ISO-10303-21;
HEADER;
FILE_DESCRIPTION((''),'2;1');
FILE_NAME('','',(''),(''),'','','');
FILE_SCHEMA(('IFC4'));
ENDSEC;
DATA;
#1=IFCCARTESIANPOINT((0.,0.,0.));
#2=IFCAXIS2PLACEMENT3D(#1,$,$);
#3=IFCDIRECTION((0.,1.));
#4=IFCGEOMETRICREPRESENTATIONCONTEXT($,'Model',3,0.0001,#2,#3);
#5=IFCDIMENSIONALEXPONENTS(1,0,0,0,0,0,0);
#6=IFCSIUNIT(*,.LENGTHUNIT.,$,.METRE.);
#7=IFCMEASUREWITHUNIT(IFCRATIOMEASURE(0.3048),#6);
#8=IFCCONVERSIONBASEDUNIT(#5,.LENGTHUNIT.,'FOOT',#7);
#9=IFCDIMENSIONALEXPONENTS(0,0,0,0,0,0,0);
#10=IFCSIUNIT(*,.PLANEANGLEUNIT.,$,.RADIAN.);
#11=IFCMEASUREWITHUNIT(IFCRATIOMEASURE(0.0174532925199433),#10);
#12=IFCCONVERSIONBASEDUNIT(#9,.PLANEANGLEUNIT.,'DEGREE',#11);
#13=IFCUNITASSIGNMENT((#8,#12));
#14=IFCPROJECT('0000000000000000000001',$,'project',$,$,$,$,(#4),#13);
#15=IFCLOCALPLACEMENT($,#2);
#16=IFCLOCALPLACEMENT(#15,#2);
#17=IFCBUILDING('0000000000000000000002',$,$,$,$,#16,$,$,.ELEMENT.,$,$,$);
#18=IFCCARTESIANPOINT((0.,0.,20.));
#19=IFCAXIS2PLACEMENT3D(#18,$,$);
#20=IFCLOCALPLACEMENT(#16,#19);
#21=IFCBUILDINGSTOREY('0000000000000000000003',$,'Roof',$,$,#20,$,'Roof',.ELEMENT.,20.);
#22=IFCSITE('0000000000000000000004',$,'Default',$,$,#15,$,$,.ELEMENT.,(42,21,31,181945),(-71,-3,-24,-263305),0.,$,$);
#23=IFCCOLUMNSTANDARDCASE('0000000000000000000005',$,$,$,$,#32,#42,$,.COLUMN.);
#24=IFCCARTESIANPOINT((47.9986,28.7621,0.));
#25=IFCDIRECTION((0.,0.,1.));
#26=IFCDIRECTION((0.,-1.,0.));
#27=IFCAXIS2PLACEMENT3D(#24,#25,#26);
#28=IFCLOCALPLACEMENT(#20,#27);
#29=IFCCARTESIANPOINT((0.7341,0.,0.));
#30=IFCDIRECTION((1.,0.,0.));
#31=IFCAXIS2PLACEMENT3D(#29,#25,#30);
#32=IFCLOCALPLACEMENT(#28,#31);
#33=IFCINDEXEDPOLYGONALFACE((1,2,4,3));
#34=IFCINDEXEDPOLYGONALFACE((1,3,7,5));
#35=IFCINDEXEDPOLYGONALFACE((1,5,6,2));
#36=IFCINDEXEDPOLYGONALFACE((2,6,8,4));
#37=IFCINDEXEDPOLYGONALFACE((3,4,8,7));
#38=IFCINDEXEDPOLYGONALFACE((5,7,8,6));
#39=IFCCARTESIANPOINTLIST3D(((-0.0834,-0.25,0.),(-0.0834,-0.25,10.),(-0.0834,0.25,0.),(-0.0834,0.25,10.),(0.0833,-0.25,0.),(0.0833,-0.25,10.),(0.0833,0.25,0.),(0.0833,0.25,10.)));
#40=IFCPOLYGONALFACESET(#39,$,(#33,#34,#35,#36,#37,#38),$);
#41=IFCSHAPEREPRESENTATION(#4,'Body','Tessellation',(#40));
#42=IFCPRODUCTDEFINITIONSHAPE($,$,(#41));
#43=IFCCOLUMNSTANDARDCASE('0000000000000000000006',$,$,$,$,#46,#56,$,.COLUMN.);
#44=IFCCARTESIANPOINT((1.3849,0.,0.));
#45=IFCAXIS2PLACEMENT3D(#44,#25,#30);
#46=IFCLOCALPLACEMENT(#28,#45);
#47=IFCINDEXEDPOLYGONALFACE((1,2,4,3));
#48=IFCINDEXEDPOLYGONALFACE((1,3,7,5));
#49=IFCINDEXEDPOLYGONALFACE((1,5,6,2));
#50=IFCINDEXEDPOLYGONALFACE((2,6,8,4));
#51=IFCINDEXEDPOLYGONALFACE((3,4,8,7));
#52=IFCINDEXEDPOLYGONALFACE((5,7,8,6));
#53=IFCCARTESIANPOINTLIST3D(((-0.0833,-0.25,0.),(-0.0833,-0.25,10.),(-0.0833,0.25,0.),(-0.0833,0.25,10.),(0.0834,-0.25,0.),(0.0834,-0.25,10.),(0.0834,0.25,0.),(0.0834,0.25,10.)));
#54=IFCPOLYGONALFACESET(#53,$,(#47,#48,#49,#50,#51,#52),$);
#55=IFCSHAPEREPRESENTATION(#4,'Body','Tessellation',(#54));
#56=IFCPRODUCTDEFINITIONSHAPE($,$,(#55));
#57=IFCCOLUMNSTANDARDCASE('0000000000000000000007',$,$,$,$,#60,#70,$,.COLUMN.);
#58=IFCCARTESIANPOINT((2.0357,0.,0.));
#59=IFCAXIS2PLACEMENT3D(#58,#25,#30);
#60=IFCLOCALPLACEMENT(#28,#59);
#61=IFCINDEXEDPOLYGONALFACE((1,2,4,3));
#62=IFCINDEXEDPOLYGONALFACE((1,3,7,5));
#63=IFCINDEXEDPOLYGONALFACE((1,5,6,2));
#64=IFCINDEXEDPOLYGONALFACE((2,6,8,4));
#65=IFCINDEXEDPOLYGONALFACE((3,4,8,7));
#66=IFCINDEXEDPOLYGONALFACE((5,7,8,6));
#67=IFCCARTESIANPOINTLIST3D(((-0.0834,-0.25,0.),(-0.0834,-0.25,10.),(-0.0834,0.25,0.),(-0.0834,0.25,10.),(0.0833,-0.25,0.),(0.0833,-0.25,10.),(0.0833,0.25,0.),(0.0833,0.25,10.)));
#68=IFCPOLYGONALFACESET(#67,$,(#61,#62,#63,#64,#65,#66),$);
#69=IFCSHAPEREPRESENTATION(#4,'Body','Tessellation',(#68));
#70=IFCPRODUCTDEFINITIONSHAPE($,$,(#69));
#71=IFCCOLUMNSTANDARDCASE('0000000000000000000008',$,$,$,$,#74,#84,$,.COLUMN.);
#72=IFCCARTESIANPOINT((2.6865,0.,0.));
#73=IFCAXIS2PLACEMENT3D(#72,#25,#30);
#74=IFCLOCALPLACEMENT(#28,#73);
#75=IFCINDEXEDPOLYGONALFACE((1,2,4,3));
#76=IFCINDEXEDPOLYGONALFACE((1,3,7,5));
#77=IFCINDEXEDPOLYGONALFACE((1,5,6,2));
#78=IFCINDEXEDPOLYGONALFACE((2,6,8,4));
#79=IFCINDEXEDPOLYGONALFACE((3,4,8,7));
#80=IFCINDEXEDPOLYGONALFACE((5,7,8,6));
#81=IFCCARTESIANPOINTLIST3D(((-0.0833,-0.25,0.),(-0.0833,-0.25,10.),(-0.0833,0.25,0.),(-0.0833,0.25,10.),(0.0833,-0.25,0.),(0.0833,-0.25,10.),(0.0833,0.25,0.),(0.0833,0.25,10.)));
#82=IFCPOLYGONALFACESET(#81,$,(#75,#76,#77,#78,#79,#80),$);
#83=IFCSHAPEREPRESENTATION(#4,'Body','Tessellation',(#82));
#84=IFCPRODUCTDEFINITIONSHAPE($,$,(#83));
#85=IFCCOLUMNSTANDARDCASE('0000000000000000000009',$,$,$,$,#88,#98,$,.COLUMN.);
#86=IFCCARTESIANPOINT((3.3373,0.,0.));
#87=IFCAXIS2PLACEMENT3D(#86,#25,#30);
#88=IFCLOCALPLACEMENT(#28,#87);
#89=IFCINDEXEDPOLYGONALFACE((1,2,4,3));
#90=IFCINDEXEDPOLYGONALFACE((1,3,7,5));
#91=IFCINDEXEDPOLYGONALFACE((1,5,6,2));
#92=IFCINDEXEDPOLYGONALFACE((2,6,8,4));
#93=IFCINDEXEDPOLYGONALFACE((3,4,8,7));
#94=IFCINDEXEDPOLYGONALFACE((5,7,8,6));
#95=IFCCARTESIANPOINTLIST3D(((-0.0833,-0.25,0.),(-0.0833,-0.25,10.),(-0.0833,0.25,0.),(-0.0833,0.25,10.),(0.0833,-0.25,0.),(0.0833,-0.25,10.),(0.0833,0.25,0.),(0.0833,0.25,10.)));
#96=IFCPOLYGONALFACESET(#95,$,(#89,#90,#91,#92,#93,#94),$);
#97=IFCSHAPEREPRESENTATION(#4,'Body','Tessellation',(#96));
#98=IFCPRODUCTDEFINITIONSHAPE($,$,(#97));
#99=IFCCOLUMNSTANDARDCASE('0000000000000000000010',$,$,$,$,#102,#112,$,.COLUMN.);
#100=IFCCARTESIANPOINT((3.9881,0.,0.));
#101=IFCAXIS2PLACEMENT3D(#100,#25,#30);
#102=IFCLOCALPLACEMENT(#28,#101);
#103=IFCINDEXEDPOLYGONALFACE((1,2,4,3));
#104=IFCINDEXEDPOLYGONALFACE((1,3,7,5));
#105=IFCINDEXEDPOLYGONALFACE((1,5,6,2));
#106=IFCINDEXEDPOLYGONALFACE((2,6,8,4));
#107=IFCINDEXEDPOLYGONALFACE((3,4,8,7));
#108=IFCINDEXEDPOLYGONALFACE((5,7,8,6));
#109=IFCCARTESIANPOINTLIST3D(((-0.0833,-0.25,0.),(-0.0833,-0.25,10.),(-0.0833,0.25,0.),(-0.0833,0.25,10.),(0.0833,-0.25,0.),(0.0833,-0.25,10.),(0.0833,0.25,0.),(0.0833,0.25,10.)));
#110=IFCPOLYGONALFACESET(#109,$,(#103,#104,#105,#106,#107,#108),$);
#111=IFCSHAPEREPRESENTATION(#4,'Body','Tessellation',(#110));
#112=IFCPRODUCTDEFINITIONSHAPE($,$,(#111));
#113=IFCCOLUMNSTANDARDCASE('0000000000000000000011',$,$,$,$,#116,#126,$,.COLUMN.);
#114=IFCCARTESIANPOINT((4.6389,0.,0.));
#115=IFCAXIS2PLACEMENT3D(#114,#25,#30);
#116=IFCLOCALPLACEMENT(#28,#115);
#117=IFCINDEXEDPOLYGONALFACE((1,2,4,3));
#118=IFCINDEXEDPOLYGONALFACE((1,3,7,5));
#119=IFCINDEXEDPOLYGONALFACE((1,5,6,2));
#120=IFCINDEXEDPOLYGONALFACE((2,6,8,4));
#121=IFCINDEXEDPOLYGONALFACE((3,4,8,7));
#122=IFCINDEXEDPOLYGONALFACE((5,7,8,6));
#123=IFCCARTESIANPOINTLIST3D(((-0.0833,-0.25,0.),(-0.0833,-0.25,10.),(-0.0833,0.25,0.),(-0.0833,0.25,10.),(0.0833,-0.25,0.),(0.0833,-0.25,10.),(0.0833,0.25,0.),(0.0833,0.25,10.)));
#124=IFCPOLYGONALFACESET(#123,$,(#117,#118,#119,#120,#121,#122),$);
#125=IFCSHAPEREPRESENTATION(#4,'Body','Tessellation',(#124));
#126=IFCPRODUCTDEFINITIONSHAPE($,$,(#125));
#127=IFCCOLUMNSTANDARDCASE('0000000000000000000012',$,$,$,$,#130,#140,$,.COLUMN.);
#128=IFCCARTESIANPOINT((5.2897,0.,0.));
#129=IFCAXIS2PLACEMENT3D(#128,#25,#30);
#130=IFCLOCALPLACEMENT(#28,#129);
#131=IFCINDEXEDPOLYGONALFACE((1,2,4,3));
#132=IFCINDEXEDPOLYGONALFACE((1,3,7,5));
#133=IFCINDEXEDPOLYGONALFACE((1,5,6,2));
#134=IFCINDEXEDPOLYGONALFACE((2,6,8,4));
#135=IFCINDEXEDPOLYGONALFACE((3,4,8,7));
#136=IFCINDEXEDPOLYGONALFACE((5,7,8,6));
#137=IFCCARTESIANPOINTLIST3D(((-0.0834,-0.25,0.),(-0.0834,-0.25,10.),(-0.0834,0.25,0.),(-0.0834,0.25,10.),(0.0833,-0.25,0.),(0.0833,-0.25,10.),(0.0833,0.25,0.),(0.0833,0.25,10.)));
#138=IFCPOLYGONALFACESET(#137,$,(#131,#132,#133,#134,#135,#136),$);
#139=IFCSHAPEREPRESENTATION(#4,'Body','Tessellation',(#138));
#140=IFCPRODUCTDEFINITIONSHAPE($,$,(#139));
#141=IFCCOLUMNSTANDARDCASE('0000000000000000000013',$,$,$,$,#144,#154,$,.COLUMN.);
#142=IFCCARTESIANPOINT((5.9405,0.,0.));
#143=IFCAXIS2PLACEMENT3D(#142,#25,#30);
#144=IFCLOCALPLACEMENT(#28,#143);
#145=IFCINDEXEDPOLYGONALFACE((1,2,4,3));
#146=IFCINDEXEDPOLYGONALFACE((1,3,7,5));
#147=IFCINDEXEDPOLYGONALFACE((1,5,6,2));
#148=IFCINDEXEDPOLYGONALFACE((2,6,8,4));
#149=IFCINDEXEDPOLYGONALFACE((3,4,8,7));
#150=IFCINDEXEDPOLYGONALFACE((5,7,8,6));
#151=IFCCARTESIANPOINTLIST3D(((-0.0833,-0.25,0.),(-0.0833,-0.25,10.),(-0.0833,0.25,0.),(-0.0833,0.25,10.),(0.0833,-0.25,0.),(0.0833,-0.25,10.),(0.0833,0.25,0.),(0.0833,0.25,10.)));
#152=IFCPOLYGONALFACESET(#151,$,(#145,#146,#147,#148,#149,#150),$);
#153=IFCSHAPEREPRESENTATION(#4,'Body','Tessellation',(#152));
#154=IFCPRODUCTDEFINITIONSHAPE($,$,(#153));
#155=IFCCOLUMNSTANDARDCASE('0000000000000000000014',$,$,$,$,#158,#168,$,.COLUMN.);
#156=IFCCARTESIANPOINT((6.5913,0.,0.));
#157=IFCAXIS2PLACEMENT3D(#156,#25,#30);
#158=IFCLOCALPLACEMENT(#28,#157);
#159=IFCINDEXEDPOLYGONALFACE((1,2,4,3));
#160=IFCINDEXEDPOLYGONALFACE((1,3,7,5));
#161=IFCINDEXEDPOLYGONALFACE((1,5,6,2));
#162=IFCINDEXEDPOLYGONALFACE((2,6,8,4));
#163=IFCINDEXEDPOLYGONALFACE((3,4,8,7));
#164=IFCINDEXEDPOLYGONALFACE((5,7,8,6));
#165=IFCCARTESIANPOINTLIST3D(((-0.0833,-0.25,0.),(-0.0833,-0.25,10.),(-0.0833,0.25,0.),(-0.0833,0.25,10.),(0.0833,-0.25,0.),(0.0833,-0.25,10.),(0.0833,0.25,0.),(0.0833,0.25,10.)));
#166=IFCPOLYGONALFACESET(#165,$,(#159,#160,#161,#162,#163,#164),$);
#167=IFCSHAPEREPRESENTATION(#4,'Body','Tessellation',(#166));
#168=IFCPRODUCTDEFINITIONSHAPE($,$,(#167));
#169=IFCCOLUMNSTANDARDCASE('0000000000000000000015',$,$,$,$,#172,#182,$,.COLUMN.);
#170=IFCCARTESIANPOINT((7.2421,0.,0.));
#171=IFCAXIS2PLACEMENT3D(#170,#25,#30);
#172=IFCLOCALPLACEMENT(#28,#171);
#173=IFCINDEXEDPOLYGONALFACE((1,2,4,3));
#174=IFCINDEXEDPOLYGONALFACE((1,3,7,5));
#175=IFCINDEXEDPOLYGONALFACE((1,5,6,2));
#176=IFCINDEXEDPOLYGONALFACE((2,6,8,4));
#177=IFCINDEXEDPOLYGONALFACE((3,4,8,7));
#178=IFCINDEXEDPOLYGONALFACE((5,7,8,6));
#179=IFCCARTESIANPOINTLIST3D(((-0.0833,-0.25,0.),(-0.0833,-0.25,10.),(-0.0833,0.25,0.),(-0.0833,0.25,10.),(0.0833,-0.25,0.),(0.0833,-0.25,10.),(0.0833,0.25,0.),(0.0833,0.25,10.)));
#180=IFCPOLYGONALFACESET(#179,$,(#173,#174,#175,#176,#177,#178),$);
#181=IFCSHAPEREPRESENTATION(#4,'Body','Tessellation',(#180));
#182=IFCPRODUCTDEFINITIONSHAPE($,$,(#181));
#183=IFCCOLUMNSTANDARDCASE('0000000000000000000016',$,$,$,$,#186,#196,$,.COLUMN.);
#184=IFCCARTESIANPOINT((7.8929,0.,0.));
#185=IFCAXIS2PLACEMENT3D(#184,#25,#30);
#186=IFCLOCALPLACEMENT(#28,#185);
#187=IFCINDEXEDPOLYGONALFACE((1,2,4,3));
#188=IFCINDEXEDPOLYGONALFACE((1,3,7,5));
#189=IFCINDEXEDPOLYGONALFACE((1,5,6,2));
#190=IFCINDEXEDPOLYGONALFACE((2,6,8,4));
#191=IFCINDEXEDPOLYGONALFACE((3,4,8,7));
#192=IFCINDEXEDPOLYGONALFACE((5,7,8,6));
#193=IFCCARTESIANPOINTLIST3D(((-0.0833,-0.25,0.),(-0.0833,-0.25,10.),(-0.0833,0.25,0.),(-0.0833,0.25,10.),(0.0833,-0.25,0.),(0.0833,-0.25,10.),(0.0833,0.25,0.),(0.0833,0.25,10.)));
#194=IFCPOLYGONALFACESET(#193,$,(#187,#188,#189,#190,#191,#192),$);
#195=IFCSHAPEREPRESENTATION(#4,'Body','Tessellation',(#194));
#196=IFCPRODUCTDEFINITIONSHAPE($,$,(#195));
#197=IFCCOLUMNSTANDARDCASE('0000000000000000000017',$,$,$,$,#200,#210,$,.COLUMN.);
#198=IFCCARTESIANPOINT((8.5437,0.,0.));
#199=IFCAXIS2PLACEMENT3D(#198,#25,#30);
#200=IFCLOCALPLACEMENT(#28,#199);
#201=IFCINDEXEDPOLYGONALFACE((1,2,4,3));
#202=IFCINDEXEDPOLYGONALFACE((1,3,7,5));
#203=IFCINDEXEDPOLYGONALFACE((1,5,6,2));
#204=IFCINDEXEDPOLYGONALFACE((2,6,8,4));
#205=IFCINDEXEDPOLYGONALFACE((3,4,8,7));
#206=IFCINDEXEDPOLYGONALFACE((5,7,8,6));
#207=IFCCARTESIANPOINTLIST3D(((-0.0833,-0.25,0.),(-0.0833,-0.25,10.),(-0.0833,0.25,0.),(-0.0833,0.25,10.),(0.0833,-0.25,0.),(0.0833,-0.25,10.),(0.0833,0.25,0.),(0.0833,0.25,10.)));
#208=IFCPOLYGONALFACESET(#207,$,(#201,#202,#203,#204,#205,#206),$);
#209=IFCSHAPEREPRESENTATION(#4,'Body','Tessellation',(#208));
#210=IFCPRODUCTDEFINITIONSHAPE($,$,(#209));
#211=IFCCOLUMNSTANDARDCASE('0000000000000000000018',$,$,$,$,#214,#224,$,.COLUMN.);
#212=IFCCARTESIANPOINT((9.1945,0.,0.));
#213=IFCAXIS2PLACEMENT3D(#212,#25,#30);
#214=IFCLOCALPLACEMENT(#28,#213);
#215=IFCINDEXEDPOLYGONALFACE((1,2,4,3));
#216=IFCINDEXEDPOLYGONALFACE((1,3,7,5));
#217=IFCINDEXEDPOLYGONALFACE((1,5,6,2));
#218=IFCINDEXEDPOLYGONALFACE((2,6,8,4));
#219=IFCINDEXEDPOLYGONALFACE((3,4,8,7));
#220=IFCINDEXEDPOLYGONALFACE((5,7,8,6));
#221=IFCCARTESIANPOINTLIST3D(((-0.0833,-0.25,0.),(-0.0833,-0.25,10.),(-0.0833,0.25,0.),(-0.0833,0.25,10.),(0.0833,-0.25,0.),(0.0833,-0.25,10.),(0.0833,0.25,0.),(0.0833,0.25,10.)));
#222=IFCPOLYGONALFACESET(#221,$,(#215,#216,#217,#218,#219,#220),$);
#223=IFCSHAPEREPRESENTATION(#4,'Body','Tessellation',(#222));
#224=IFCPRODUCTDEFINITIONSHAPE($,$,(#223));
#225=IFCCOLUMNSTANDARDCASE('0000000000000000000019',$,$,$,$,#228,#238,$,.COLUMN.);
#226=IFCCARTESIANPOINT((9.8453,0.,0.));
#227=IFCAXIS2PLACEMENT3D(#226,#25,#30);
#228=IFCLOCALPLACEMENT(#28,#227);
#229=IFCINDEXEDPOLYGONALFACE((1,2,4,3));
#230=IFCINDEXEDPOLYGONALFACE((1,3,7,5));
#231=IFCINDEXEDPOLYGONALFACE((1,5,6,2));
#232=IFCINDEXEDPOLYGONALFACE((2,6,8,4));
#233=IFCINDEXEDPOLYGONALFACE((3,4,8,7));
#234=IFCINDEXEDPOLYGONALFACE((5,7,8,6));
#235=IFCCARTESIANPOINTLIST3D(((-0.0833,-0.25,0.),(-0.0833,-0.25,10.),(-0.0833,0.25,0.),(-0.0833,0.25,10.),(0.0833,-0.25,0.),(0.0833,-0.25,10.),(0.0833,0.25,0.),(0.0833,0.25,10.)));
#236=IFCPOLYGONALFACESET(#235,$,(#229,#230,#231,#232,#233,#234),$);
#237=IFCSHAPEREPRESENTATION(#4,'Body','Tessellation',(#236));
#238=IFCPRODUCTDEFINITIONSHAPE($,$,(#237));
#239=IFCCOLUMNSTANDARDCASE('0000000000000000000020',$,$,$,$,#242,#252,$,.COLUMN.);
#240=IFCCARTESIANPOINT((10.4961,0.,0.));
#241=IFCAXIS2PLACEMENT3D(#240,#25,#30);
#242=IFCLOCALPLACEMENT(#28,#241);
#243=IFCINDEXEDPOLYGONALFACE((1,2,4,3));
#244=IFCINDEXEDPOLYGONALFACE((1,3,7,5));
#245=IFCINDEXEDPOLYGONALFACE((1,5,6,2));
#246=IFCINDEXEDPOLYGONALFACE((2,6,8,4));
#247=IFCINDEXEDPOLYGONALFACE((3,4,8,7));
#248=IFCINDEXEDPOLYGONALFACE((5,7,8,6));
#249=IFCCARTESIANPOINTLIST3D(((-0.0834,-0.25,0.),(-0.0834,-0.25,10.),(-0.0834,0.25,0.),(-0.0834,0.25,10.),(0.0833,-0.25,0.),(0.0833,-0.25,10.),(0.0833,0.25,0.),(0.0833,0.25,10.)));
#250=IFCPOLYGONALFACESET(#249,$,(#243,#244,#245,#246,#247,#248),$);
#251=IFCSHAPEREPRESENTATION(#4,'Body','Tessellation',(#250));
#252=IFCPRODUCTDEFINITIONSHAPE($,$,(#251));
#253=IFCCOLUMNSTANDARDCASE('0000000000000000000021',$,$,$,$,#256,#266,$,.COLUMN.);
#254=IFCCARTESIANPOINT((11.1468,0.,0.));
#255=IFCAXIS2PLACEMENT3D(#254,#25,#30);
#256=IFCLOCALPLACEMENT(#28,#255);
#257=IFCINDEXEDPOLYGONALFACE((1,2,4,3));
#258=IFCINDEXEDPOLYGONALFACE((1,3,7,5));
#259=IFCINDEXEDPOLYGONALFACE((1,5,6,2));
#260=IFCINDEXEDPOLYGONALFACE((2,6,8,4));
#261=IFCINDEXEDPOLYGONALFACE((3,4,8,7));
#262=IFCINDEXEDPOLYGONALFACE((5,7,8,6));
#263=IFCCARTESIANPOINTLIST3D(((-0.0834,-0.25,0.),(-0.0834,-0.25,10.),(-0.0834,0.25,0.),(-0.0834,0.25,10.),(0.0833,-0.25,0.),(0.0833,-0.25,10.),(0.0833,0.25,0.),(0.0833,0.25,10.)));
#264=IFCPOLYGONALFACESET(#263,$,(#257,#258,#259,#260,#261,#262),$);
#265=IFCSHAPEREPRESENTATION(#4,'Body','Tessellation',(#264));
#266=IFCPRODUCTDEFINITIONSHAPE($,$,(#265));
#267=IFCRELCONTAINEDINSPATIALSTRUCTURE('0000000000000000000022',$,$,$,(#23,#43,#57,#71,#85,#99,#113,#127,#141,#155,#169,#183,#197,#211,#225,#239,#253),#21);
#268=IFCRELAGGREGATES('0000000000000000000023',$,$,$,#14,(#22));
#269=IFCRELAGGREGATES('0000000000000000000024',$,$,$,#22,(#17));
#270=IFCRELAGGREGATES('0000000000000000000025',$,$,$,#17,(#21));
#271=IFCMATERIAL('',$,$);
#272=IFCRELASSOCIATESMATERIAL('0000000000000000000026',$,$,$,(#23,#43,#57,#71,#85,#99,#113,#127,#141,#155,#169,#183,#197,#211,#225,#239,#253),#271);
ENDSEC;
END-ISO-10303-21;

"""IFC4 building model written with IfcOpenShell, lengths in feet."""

from ifc_helpers import new_model, entity, si_unit, converted_unit, direction, frame, origin, place, context, project, spatial, rectangle, extrude, material, element, save


model = new_model("IFC4")

# Units and contexts
model_context = context("Model", 3, precision=0.0001, world=origin(), true_north=direction((0.0, 1.0)))
ifc_project = project(units=[converted_unit("LENGTHUNIT", "FOOT", entity("IfcRatioMeasure", 0.3048), si_unit("LENGTHUNIT", "METRE"), dimensions=[1, 0, 0, 0, 0, 0, 0]), converted_unit("PLANEANGLEUNIT", "DEGREE", entity("IfcRatioMeasure", 0.0174532925199433), si_unit("PLANEANGLEUNIT", "RADIAN"), dimensions=[0, 0, 0, 0, 0, 0, 0])], contexts=[model_context])

# Site, building, storey
site_placement = place(None, origin())
site = spatial("IfcSite", under=ifc_project, at=site_placement, Name="Default", CompositionType="ELEMENT", RefLatitude=(42, 21, 31, 181945), RefLongitude=(-71, -3, -24, -263305), RefElevation=0.0)
building_placement = place(site_placement, origin())
building = spatial("IfcBuilding", under=site, at=building_placement, CompositionType="ELEMENT")
storey_placement = place(building_placement, frame((0.0, 0.0, 20.0)))
storey = spatial("IfcBuildingStorey", under=building, at=storey_placement, Name="Roof", LongName="Roof", CompositionType="ELEMENT", Elevation=20.0)

# Columns
ifc_material_1 = material(Name="")
placement_1 = place(storey_placement, frame((47.9986, 28.7621, 0.0), z_axis=(0.0, 0.0, 1.0), x_axis=(0.0, -1.0, 0.0)))
for number, where, z_axis, x_axis in (
    (1, (0.7341, 0.0, 0.0), (0.0, 0.0, 1.0), (1.0, 0.0, 0.0)),
    (2, (1.3849, 0.0, 0.0), (0.0, 0.0, 1.0), (1.0, 0.0, 0.0)),
    (3, (2.0357, 0.0, 0.0), (0.0, 0.0, 1.0), (1.0, 0.0, 0.0)),
    (4, (2.6865, 0.0, 0.0), (0.0, 0.0, 1.0), (1.0, 0.0, 0.0)),
    (5, (3.3373, 0.0, 0.0), (0.0, 0.0, 1.0), (1.0, 0.0, 0.0)),
    (6, (3.9881, 0.0, 0.0), (0.0, 0.0, 1.0), (1.0, 0.0, 0.0)),
    (7, (4.6389, 0.0, 0.0), (0.0, 0.0, 1.0), (1.0, 0.0, 0.0)),
    (8, (5.2897, 0.0, 0.0), (0.0, 0.0, 1.0), (1.0, 0.0, 0.0)),
    (9, (5.9405, 0.0, 0.0), (0.0, 0.0, 1.0), (1.0, 0.0, 0.0)),
    (10, (6.5913, 0.0, 0.0), (0.0, 0.0, 1.0), (1.0, 0.0, 0.0)),
    (11, (7.2421, 0.0, 0.0), (0.0, 0.0, 1.0), (1.0, 0.0, 0.0)),
    (12, (7.8929, 0.0, 0.0), (0.0, 0.0, 1.0), (1.0, 0.0, 0.0)),
    (13, (8.5437, 0.0, 0.0), (0.0, 0.0, 1.0), (1.0, 0.0, 0.0)),
    (14, (9.1945, 0.0, 0.0), (0.0, 0.0, 1.0), (1.0, 0.0, 0.0)),
    (15, (9.8453, 0.0, 0.0), (0.0, 0.0, 1.0), (1.0, 0.0, 0.0)),
    (16, (10.4961, 0.0, 0.0), (0.0, 0.0, 1.0), (1.0, 0.0, 0.0)),
    (17, (11.1468, 0.0, 0.0), (0.0, 0.0, 1.0), (1.0, 0.0, 0.0)),
):
    element("IfcColumnStandardCase", number, at=place(placement_1, frame(where, z_axis=z_axis, x_axis=x_axis)), inside=storey, material=ifc_material_1, PredefinedType="COLUMN", context=model_context, shape_type="SweptSolid", body=[
        extrude(rectangle(XDim=0.1667, YDim=0.5), origin(), (0.0, 0.0, 1.0), 10.0),
    ])

save(model, "model.ifc")
